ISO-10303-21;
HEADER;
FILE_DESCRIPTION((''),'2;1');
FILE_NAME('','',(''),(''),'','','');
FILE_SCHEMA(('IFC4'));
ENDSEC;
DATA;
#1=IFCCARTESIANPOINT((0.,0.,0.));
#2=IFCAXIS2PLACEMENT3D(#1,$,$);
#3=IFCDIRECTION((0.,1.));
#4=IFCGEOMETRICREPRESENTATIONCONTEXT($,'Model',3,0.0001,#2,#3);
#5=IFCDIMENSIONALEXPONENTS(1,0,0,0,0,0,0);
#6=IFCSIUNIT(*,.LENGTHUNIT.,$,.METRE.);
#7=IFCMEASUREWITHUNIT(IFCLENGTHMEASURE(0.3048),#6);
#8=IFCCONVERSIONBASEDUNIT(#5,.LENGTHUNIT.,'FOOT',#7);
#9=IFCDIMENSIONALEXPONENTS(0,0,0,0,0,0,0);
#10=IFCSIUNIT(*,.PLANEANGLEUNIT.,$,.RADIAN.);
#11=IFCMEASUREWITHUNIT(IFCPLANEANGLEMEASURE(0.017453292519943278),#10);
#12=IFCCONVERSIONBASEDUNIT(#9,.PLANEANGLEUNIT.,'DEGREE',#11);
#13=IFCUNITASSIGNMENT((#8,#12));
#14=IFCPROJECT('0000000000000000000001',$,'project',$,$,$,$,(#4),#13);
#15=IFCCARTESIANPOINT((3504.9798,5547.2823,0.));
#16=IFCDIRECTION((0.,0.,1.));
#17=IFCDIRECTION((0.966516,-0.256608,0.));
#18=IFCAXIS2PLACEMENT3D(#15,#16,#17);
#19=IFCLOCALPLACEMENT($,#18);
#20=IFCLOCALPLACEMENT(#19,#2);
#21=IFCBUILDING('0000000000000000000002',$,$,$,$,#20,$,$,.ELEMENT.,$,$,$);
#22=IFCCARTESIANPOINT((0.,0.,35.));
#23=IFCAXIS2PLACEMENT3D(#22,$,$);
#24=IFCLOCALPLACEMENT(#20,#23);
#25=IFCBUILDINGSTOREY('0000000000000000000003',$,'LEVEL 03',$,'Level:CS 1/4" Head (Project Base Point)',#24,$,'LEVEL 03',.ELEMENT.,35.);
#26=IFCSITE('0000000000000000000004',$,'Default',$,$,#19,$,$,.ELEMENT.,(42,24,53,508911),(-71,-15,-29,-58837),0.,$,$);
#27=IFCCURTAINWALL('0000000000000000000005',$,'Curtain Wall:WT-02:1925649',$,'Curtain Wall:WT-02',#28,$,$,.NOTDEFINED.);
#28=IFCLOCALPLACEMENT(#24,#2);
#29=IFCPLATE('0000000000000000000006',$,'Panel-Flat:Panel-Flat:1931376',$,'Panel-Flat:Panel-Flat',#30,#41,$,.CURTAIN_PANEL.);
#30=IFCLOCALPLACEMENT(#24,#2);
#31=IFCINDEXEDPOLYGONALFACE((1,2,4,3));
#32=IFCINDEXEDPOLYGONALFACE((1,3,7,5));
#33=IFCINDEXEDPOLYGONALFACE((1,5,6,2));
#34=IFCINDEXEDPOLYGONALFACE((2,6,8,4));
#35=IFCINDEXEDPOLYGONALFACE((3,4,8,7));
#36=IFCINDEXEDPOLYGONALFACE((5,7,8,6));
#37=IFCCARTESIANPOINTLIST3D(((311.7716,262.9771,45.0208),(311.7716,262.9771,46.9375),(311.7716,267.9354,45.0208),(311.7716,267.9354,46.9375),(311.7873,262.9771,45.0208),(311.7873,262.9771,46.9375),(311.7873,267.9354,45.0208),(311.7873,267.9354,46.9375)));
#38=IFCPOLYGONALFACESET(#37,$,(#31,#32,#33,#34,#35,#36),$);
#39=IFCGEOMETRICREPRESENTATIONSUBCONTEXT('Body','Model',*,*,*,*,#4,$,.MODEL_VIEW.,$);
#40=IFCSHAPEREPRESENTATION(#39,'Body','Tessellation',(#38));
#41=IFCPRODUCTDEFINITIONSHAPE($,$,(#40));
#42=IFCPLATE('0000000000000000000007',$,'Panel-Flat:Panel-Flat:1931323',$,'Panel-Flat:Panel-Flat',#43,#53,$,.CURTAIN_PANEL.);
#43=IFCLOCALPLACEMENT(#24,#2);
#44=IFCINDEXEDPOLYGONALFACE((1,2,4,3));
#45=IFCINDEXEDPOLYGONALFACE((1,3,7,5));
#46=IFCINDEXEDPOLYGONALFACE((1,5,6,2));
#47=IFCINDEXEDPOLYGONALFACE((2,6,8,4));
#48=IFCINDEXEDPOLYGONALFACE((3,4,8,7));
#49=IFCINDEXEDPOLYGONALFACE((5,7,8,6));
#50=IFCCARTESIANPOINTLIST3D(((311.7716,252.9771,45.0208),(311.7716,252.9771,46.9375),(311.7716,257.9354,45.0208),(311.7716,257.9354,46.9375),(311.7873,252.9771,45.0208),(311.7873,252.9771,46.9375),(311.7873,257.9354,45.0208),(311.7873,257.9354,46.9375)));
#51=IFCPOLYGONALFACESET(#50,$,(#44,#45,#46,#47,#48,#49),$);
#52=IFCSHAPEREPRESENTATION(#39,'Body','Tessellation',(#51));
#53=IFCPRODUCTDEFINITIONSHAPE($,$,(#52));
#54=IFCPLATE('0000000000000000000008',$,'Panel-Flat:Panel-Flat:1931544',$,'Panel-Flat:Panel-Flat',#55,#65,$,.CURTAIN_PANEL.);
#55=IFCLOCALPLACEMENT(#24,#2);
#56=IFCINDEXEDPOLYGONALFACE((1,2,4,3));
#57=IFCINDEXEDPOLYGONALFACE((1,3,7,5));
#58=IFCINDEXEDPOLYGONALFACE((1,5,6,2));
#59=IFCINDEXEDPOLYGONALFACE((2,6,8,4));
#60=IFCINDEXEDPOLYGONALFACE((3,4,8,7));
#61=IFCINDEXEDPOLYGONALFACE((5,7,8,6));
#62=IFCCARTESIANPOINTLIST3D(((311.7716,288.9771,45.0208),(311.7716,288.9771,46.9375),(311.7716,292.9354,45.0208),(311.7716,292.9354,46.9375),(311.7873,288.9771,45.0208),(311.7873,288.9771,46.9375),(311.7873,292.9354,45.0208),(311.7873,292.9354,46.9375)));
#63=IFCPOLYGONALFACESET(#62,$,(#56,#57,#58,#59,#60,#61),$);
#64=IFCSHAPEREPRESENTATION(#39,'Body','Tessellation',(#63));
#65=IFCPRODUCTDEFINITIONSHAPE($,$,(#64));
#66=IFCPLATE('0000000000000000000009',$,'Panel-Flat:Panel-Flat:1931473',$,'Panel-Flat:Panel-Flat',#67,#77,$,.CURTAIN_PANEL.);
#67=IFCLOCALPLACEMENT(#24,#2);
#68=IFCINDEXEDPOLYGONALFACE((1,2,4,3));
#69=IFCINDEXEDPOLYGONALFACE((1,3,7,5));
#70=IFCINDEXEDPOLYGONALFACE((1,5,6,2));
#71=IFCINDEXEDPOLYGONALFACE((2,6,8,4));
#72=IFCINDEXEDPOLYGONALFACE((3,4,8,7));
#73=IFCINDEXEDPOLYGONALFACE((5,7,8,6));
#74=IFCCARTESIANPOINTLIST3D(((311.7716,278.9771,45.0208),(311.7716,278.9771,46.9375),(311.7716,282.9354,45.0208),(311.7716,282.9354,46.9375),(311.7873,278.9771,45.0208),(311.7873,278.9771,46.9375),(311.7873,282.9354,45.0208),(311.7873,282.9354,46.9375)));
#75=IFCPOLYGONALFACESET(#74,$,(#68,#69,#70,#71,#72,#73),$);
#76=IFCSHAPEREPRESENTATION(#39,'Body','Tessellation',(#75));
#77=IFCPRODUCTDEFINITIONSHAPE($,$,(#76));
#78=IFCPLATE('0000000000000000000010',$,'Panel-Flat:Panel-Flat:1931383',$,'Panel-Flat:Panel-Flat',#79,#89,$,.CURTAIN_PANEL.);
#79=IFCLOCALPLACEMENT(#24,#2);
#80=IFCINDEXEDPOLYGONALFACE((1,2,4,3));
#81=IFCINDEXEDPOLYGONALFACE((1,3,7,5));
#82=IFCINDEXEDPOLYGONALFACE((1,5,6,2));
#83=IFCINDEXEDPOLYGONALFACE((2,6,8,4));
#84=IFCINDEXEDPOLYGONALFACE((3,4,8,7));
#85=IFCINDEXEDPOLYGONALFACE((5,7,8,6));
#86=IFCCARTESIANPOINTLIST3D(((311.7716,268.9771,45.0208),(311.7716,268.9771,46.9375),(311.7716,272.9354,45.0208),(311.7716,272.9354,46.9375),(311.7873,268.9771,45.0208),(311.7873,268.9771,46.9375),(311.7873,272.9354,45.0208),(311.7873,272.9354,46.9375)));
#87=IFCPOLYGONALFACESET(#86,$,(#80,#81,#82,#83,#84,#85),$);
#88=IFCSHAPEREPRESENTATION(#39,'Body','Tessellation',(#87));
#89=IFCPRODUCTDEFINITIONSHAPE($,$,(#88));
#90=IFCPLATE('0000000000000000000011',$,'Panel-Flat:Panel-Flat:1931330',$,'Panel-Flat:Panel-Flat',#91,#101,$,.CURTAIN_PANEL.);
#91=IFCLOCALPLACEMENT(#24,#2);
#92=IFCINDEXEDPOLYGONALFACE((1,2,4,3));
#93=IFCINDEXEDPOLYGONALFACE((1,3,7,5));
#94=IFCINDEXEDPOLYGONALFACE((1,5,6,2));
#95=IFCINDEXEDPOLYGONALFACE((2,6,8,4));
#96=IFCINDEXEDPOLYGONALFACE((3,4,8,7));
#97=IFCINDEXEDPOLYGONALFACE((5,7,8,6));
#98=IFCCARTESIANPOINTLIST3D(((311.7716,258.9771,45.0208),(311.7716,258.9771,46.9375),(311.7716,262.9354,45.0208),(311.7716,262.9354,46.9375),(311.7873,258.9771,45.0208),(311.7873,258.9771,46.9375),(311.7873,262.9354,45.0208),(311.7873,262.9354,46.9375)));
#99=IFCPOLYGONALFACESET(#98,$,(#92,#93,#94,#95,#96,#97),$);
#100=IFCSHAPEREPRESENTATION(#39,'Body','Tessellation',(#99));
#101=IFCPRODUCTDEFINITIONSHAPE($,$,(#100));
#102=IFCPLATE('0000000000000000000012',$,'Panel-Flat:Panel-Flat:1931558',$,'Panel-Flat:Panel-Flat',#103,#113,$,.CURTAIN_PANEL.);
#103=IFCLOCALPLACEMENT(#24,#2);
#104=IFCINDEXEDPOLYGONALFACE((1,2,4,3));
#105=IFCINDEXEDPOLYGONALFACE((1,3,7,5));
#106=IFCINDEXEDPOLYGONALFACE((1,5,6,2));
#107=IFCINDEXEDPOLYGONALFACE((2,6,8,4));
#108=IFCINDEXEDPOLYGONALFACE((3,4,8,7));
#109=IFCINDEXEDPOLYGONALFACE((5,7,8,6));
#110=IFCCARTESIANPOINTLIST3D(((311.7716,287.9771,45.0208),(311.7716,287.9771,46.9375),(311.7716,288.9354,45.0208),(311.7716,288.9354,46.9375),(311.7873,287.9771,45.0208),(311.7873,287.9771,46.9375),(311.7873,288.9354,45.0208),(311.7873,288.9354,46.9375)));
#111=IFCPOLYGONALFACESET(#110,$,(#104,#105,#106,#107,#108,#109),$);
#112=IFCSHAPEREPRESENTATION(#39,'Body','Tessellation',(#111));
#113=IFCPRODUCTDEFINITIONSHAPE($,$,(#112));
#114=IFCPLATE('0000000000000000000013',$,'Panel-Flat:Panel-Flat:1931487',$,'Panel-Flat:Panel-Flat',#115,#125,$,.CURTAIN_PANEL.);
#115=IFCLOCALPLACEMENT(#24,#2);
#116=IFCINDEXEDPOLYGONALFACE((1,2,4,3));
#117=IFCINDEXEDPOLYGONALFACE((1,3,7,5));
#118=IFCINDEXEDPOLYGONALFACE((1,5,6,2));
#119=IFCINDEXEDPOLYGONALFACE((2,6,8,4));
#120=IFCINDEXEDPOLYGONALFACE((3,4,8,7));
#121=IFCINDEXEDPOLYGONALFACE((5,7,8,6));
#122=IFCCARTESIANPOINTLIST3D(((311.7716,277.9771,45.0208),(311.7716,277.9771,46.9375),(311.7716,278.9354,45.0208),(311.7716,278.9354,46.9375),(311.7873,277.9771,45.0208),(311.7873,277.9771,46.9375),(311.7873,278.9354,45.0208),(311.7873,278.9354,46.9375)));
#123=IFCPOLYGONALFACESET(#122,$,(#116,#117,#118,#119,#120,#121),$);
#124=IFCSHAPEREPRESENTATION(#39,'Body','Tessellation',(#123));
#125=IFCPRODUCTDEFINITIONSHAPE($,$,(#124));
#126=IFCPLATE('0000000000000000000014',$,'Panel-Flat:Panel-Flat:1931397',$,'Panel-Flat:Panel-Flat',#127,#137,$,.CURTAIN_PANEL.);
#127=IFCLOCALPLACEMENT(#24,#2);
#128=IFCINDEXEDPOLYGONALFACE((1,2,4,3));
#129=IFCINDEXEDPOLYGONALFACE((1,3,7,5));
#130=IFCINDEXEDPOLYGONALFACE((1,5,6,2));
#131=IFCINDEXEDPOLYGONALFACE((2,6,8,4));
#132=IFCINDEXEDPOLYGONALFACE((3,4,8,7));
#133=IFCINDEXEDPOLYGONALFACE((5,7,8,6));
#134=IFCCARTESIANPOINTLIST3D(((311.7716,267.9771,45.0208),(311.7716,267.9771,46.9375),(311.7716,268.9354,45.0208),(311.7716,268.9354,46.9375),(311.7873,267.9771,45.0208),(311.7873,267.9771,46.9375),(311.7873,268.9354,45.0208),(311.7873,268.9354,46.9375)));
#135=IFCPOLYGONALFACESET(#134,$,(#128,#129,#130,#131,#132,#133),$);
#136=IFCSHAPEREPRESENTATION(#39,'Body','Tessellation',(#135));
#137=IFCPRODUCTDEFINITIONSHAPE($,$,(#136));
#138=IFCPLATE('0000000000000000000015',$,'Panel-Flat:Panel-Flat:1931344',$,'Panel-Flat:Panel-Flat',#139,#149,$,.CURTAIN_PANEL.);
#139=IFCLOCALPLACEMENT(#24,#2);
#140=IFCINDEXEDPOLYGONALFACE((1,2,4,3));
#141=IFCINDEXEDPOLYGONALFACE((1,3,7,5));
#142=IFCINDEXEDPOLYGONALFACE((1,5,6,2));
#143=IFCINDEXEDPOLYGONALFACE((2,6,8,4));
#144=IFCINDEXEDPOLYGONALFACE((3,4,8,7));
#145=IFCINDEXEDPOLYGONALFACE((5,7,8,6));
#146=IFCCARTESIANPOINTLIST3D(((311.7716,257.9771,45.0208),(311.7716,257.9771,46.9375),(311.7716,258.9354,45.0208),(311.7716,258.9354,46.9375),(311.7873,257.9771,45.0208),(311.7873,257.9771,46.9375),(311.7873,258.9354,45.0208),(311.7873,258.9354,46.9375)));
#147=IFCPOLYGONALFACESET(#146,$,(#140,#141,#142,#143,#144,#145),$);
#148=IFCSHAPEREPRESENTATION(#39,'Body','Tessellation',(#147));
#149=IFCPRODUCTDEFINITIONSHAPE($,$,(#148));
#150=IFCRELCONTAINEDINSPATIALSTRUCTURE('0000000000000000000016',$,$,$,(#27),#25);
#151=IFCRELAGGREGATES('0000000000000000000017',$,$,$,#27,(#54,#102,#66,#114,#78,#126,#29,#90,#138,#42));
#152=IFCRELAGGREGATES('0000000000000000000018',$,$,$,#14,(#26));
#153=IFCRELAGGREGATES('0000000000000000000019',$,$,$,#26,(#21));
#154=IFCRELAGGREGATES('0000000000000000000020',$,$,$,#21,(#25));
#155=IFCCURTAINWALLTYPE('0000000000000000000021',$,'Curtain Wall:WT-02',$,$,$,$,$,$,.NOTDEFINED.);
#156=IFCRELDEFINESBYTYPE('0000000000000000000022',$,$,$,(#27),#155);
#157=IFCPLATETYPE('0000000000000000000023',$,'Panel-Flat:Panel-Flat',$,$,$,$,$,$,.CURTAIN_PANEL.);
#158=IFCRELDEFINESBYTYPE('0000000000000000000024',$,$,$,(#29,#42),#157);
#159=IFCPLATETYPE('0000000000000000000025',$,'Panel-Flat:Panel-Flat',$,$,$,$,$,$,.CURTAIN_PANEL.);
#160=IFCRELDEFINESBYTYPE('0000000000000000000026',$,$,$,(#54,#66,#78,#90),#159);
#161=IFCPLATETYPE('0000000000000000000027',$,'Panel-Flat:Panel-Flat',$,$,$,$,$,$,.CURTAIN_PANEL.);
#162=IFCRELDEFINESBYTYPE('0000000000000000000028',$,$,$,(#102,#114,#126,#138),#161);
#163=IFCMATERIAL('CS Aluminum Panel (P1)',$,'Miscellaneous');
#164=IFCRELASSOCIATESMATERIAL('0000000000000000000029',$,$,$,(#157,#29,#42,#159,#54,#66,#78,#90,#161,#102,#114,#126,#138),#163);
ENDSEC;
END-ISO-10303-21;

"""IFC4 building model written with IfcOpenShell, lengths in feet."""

from ifc_helpers import new_model, entity, si_unit, converted_unit, direction, frame, origin, place, context, subcontext, project, spatial, indexed_curve, outline, extrude, source, transform, mapped, material, type_object, type_shapes, element, aggregate, save


model = new_model("IFC4")

# Units and contexts
model_context = context("Model", 3, precision=0.0001, world=origin(), true_north=direction((0.0, 1.0)))
body_context = subcontext(model_context, "Body", "Model", "MODEL_VIEW")
ifc_project = project(units=[converted_unit("LENGTHUNIT", "FOOT", entity("IfcLengthMeasure", 0.3048), si_unit("LENGTHUNIT", "METRE"), dimensions=[1, 0, 0, 0, 0, 0, 0]), converted_unit("PLANEANGLEUNIT", "DEGREE", entity("IfcPlaneAngleMeasure", 0.017453292519943278), si_unit("PLANEANGLEUNIT", "RADIAN"), dimensions=[0, 0, 0, 0, 0, 0, 0])], contexts=[model_context])

# Site, building, storey
site_placement = place(None, frame((3504.9798, 5547.2823, 0.0), z_axis=(0.0, 0.0, 1.0), x_axis=(0.966516, -0.256608, 0.0)))
site = spatial("IfcSite", under=ifc_project, at=site_placement, Name="Default", CompositionType="ELEMENT", RefLatitude=(42, 24, 53, 508911), RefLongitude=(-71, -15, -29, -58837), RefElevation=0.0)
building_placement = place(site_placement, origin())
building = spatial("IfcBuilding", under=site, at=building_placement, CompositionType="ELEMENT")
storey_placement = place(building_placement, frame((0.0, 0.0, 35.0)))
storey = spatial("IfcBuildingStorey", under=building, at=storey_placement, Name="LEVEL 03", ObjectType="Level:CS 1/4\" Head (Project Base Point)", LongName="LEVEL 03", CompositionType="ELEMENT", Elevation=35.0)

# Curtain wall, plates
curtain_wall_type = type_object("IfcCurtainWallType", Name="Curtain Wall:WT-02", PredefinedType="NOTDEFINED")
curtain_wall_placement = place(storey_placement, frame((0.0, 0.0, -35.0)))
curtain_wall = element("IfcCurtainWall", 1, at=curtain_wall_placement, inside=storey, type_object=curtain_wall_type, Name="Curtain Wall:WT-02:1925649", ObjectType="Curtain Wall:WT-02", PredefinedType="NOTDEFINED")
ifc_material = material(Name="CS Aluminum Panel (P1)", Category="Miscellaneous")
plate_type_1 = type_object("IfcPlateType", Name="Panel-Flat:Panel-Flat", PredefinedType="CURTAIN_PANEL", material=ifc_material)
shared_shape_1 = source(origin(), body_context, "Body", "SweptSolid", [
    extrude(outline(indexed_curve([(-0.0078, -2.4792), (0.0078, -2.4792), (0.0078, 2.4792), (-0.0078, 2.4792), (-0.0078, -2.4792)], self_intersect=False)), frame((2.4792, 0.0078, 0.0), z_axis=(0.0, 0.0, 1.0), x_axis=(0.0, -1.0, 0.0)), (0.0, 0.0, 1.0), 1.9167),
])
type_shapes(plate_type_1, [shared_shape_1])
plate_1_placement = place(curtain_wall_placement, frame((311.7716, 267.9354, 80.0208), z_axis=(0.0, 0.0, 1.0), x_axis=(0.0, -1.0, 0.0)))
plate_1 = element("IfcPlate", 2, at=plate_1_placement, type_object=plate_type_1, material=ifc_material, Name="Panel-Flat:Panel-Flat:1931376", ObjectType="Panel-Flat:Panel-Flat", PredefinedType="CURTAIN_PANEL", context=body_context, shape_type="MappedRepresentation", body=[
    mapped(shared_shape_1, transform((0.0, 0.0, 0.0), scale=1.0)),
])
plate_2_placement = place(curtain_wall_placement, frame((311.7716, 257.9354, 80.0208), z_axis=(0.0, 0.0, 1.0), x_axis=(0.0, -1.0, 0.0)))
plate_2 = element("IfcPlate", 3, at=plate_2_placement, type_object=plate_type_1, material=ifc_material, Name="Panel-Flat:Panel-Flat:1931323", ObjectType="Panel-Flat:Panel-Flat", PredefinedType="CURTAIN_PANEL", context=body_context, shape_type="MappedRepresentation", body=[
    mapped(shared_shape_1, transform((0.0, 0.0, 0.0), scale=1.0)),
])
plate_type_2 = type_object("IfcPlateType", Name="Panel-Flat:Panel-Flat", PredefinedType="CURTAIN_PANEL", material=ifc_material)
shared_shape_2 = source(origin(), body_context, "Body", "SweptSolid", [
    extrude(outline(indexed_curve([(-0.0078, -1.9792), (0.0078, -1.9792), (0.0078, 1.9792), (-0.0078, 1.9792), (-0.0078, -1.9792)], self_intersect=False)), frame((1.9792, 0.0078, 0.0), z_axis=(0.0, 0.0, 1.0), x_axis=(0.0, -1.0, 0.0)), (0.0, 0.0, 1.0), 1.9167),
])
type_shapes(plate_type_2, [shared_shape_2])
plate_3_placement = place(curtain_wall_placement, frame((311.7716, 292.9354, 80.0208), z_axis=(0.0, 0.0, 1.0), x_axis=(0.0, -1.0, 0.0)))
plate_3 = element("IfcPlate", 4, at=plate_3_placement, type_object=plate_type_2, material=ifc_material, Name="Panel-Flat:Panel-Flat:1931544", ObjectType="Panel-Flat:Panel-Flat", PredefinedType="CURTAIN_PANEL", context=body_context, shape_type="MappedRepresentation", body=[
    mapped(shared_shape_2, transform((0.0, 0.0, 0.0), scale=1.0)),
])
plate_4_placement = place(curtain_wall_placement, frame((311.7716, 282.9354, 80.0208), z_axis=(0.0, 0.0, 1.0), x_axis=(0.0, -1.0, 0.0)))
plate_4 = element("IfcPlate", 5, at=plate_4_placement, type_object=plate_type_2, material=ifc_material, Name="Panel-Flat:Panel-Flat:1931473", ObjectType="Panel-Flat:Panel-Flat", PredefinedType="CURTAIN_PANEL", context=body_context, shape_type="MappedRepresentation", body=[
    mapped(shared_shape_2, transform((0.0, 0.0, 0.0), scale=1.0)),
])
plate_5_placement = place(curtain_wall_placement, frame((311.7716, 272.9354, 80.0208), z_axis=(0.0, 0.0, 1.0), x_axis=(0.0, -1.0, 0.0)))
plate_5 = element("IfcPlate", 6, at=plate_5_placement, type_object=plate_type_2, material=ifc_material, Name="Panel-Flat:Panel-Flat:1931383", ObjectType="Panel-Flat:Panel-Flat", PredefinedType="CURTAIN_PANEL", context=body_context, shape_type="MappedRepresentation", body=[
    mapped(shared_shape_2, transform((0.0, 0.0, 0.0), scale=1.0)),
])
plate_6_placement = place(curtain_wall_placement, frame((311.7716, 262.9354, 80.0208), z_axis=(0.0, 0.0, 1.0), x_axis=(0.0, -1.0, 0.0)))
plate_6 = element("IfcPlate", 7, at=plate_6_placement, type_object=plate_type_2, material=ifc_material, Name="Panel-Flat:Panel-Flat:1931330", ObjectType="Panel-Flat:Panel-Flat", PredefinedType="CURTAIN_PANEL", context=body_context, shape_type="MappedRepresentation", body=[
    mapped(shared_shape_2, transform((0.0, 0.0, 0.0), scale=1.0)),
])
plate_type_3 = type_object("IfcPlateType", Name="Panel-Flat:Panel-Flat", PredefinedType="CURTAIN_PANEL", material=ifc_material)
shared_shape_3 = source(origin(), body_context, "Body", "SweptSolid", [
    extrude(outline(indexed_curve([(-0.0078, -0.4792), (0.0078, -0.4792), (0.0078, 0.4792), (-0.0078, 0.4792), (-0.0078, -0.4792)], self_intersect=False)), frame((0.4792, 0.0078, 0.0), z_axis=(0.0, 0.0, 1.0), x_axis=(0.0, -1.0, 0.0)), (0.0, 0.0, 1.0), 1.9167),
])
type_shapes(plate_type_3, [shared_shape_3])
plate_7_placement = place(curtain_wall_placement, frame((311.7716, 288.9354, 80.0208), z_axis=(0.0, 0.0, 1.0), x_axis=(0.0, -1.0, 0.0)))
plate_7 = element("IfcPlate", 8, at=plate_7_placement, type_object=plate_type_3, material=ifc_material, Name="Panel-Flat:Panel-Flat:1931558", ObjectType="Panel-Flat:Panel-Flat", PredefinedType="CURTAIN_PANEL", context=body_context, shape_type="MappedRepresentation", body=[
    mapped(shared_shape_3, transform((0.0, 0.0, 0.0), scale=1.0)),
])
plate_8_placement = place(curtain_wall_placement, frame((311.7716, 278.9354, 80.0208), z_axis=(0.0, 0.0, 1.0), x_axis=(0.0, -1.0, 0.0)))
plate_8 = element("IfcPlate", 9, at=plate_8_placement, type_object=plate_type_3, material=ifc_material, Name="Panel-Flat:Panel-Flat:1931487", ObjectType="Panel-Flat:Panel-Flat", PredefinedType="CURTAIN_PANEL", context=body_context, shape_type="MappedRepresentation", body=[
    mapped(shared_shape_3, transform((0.0, 0.0, 0.0), scale=1.0)),
])
plate_9_placement = place(curtain_wall_placement, frame((311.7716, 268.9354, 80.0208), z_axis=(0.0, 0.0, 1.0), x_axis=(0.0, -1.0, 0.0)))
plate_9 = element("IfcPlate", 10, at=plate_9_placement, type_object=plate_type_3, material=ifc_material, Name="Panel-Flat:Panel-Flat:1931397", ObjectType="Panel-Flat:Panel-Flat", PredefinedType="CURTAIN_PANEL", context=body_context, shape_type="MappedRepresentation", body=[
    mapped(shared_shape_3, transform((0.0, 0.0, 0.0), scale=1.0)),
])
plate_10_placement = place(curtain_wall_placement, frame((311.7716, 258.9354, 80.0208), z_axis=(0.0, 0.0, 1.0), x_axis=(0.0, -1.0, 0.0)))
plate_10 = element("IfcPlate", 11, at=plate_10_placement, type_object=plate_type_3, material=ifc_material, Name="Panel-Flat:Panel-Flat:1931344", ObjectType="Panel-Flat:Panel-Flat", PredefinedType="CURTAIN_PANEL", context=body_context, shape_type="MappedRepresentation", body=[
    mapped(shared_shape_3, transform((0.0, 0.0, 0.0), scale=1.0)),
])
aggregate(curtain_wall, [plate_3, plate_7, plate_4, plate_8, plate_5, plate_9, plate_1, plate_6, plate_10, plate_2])

save(model, "model.ifc")
